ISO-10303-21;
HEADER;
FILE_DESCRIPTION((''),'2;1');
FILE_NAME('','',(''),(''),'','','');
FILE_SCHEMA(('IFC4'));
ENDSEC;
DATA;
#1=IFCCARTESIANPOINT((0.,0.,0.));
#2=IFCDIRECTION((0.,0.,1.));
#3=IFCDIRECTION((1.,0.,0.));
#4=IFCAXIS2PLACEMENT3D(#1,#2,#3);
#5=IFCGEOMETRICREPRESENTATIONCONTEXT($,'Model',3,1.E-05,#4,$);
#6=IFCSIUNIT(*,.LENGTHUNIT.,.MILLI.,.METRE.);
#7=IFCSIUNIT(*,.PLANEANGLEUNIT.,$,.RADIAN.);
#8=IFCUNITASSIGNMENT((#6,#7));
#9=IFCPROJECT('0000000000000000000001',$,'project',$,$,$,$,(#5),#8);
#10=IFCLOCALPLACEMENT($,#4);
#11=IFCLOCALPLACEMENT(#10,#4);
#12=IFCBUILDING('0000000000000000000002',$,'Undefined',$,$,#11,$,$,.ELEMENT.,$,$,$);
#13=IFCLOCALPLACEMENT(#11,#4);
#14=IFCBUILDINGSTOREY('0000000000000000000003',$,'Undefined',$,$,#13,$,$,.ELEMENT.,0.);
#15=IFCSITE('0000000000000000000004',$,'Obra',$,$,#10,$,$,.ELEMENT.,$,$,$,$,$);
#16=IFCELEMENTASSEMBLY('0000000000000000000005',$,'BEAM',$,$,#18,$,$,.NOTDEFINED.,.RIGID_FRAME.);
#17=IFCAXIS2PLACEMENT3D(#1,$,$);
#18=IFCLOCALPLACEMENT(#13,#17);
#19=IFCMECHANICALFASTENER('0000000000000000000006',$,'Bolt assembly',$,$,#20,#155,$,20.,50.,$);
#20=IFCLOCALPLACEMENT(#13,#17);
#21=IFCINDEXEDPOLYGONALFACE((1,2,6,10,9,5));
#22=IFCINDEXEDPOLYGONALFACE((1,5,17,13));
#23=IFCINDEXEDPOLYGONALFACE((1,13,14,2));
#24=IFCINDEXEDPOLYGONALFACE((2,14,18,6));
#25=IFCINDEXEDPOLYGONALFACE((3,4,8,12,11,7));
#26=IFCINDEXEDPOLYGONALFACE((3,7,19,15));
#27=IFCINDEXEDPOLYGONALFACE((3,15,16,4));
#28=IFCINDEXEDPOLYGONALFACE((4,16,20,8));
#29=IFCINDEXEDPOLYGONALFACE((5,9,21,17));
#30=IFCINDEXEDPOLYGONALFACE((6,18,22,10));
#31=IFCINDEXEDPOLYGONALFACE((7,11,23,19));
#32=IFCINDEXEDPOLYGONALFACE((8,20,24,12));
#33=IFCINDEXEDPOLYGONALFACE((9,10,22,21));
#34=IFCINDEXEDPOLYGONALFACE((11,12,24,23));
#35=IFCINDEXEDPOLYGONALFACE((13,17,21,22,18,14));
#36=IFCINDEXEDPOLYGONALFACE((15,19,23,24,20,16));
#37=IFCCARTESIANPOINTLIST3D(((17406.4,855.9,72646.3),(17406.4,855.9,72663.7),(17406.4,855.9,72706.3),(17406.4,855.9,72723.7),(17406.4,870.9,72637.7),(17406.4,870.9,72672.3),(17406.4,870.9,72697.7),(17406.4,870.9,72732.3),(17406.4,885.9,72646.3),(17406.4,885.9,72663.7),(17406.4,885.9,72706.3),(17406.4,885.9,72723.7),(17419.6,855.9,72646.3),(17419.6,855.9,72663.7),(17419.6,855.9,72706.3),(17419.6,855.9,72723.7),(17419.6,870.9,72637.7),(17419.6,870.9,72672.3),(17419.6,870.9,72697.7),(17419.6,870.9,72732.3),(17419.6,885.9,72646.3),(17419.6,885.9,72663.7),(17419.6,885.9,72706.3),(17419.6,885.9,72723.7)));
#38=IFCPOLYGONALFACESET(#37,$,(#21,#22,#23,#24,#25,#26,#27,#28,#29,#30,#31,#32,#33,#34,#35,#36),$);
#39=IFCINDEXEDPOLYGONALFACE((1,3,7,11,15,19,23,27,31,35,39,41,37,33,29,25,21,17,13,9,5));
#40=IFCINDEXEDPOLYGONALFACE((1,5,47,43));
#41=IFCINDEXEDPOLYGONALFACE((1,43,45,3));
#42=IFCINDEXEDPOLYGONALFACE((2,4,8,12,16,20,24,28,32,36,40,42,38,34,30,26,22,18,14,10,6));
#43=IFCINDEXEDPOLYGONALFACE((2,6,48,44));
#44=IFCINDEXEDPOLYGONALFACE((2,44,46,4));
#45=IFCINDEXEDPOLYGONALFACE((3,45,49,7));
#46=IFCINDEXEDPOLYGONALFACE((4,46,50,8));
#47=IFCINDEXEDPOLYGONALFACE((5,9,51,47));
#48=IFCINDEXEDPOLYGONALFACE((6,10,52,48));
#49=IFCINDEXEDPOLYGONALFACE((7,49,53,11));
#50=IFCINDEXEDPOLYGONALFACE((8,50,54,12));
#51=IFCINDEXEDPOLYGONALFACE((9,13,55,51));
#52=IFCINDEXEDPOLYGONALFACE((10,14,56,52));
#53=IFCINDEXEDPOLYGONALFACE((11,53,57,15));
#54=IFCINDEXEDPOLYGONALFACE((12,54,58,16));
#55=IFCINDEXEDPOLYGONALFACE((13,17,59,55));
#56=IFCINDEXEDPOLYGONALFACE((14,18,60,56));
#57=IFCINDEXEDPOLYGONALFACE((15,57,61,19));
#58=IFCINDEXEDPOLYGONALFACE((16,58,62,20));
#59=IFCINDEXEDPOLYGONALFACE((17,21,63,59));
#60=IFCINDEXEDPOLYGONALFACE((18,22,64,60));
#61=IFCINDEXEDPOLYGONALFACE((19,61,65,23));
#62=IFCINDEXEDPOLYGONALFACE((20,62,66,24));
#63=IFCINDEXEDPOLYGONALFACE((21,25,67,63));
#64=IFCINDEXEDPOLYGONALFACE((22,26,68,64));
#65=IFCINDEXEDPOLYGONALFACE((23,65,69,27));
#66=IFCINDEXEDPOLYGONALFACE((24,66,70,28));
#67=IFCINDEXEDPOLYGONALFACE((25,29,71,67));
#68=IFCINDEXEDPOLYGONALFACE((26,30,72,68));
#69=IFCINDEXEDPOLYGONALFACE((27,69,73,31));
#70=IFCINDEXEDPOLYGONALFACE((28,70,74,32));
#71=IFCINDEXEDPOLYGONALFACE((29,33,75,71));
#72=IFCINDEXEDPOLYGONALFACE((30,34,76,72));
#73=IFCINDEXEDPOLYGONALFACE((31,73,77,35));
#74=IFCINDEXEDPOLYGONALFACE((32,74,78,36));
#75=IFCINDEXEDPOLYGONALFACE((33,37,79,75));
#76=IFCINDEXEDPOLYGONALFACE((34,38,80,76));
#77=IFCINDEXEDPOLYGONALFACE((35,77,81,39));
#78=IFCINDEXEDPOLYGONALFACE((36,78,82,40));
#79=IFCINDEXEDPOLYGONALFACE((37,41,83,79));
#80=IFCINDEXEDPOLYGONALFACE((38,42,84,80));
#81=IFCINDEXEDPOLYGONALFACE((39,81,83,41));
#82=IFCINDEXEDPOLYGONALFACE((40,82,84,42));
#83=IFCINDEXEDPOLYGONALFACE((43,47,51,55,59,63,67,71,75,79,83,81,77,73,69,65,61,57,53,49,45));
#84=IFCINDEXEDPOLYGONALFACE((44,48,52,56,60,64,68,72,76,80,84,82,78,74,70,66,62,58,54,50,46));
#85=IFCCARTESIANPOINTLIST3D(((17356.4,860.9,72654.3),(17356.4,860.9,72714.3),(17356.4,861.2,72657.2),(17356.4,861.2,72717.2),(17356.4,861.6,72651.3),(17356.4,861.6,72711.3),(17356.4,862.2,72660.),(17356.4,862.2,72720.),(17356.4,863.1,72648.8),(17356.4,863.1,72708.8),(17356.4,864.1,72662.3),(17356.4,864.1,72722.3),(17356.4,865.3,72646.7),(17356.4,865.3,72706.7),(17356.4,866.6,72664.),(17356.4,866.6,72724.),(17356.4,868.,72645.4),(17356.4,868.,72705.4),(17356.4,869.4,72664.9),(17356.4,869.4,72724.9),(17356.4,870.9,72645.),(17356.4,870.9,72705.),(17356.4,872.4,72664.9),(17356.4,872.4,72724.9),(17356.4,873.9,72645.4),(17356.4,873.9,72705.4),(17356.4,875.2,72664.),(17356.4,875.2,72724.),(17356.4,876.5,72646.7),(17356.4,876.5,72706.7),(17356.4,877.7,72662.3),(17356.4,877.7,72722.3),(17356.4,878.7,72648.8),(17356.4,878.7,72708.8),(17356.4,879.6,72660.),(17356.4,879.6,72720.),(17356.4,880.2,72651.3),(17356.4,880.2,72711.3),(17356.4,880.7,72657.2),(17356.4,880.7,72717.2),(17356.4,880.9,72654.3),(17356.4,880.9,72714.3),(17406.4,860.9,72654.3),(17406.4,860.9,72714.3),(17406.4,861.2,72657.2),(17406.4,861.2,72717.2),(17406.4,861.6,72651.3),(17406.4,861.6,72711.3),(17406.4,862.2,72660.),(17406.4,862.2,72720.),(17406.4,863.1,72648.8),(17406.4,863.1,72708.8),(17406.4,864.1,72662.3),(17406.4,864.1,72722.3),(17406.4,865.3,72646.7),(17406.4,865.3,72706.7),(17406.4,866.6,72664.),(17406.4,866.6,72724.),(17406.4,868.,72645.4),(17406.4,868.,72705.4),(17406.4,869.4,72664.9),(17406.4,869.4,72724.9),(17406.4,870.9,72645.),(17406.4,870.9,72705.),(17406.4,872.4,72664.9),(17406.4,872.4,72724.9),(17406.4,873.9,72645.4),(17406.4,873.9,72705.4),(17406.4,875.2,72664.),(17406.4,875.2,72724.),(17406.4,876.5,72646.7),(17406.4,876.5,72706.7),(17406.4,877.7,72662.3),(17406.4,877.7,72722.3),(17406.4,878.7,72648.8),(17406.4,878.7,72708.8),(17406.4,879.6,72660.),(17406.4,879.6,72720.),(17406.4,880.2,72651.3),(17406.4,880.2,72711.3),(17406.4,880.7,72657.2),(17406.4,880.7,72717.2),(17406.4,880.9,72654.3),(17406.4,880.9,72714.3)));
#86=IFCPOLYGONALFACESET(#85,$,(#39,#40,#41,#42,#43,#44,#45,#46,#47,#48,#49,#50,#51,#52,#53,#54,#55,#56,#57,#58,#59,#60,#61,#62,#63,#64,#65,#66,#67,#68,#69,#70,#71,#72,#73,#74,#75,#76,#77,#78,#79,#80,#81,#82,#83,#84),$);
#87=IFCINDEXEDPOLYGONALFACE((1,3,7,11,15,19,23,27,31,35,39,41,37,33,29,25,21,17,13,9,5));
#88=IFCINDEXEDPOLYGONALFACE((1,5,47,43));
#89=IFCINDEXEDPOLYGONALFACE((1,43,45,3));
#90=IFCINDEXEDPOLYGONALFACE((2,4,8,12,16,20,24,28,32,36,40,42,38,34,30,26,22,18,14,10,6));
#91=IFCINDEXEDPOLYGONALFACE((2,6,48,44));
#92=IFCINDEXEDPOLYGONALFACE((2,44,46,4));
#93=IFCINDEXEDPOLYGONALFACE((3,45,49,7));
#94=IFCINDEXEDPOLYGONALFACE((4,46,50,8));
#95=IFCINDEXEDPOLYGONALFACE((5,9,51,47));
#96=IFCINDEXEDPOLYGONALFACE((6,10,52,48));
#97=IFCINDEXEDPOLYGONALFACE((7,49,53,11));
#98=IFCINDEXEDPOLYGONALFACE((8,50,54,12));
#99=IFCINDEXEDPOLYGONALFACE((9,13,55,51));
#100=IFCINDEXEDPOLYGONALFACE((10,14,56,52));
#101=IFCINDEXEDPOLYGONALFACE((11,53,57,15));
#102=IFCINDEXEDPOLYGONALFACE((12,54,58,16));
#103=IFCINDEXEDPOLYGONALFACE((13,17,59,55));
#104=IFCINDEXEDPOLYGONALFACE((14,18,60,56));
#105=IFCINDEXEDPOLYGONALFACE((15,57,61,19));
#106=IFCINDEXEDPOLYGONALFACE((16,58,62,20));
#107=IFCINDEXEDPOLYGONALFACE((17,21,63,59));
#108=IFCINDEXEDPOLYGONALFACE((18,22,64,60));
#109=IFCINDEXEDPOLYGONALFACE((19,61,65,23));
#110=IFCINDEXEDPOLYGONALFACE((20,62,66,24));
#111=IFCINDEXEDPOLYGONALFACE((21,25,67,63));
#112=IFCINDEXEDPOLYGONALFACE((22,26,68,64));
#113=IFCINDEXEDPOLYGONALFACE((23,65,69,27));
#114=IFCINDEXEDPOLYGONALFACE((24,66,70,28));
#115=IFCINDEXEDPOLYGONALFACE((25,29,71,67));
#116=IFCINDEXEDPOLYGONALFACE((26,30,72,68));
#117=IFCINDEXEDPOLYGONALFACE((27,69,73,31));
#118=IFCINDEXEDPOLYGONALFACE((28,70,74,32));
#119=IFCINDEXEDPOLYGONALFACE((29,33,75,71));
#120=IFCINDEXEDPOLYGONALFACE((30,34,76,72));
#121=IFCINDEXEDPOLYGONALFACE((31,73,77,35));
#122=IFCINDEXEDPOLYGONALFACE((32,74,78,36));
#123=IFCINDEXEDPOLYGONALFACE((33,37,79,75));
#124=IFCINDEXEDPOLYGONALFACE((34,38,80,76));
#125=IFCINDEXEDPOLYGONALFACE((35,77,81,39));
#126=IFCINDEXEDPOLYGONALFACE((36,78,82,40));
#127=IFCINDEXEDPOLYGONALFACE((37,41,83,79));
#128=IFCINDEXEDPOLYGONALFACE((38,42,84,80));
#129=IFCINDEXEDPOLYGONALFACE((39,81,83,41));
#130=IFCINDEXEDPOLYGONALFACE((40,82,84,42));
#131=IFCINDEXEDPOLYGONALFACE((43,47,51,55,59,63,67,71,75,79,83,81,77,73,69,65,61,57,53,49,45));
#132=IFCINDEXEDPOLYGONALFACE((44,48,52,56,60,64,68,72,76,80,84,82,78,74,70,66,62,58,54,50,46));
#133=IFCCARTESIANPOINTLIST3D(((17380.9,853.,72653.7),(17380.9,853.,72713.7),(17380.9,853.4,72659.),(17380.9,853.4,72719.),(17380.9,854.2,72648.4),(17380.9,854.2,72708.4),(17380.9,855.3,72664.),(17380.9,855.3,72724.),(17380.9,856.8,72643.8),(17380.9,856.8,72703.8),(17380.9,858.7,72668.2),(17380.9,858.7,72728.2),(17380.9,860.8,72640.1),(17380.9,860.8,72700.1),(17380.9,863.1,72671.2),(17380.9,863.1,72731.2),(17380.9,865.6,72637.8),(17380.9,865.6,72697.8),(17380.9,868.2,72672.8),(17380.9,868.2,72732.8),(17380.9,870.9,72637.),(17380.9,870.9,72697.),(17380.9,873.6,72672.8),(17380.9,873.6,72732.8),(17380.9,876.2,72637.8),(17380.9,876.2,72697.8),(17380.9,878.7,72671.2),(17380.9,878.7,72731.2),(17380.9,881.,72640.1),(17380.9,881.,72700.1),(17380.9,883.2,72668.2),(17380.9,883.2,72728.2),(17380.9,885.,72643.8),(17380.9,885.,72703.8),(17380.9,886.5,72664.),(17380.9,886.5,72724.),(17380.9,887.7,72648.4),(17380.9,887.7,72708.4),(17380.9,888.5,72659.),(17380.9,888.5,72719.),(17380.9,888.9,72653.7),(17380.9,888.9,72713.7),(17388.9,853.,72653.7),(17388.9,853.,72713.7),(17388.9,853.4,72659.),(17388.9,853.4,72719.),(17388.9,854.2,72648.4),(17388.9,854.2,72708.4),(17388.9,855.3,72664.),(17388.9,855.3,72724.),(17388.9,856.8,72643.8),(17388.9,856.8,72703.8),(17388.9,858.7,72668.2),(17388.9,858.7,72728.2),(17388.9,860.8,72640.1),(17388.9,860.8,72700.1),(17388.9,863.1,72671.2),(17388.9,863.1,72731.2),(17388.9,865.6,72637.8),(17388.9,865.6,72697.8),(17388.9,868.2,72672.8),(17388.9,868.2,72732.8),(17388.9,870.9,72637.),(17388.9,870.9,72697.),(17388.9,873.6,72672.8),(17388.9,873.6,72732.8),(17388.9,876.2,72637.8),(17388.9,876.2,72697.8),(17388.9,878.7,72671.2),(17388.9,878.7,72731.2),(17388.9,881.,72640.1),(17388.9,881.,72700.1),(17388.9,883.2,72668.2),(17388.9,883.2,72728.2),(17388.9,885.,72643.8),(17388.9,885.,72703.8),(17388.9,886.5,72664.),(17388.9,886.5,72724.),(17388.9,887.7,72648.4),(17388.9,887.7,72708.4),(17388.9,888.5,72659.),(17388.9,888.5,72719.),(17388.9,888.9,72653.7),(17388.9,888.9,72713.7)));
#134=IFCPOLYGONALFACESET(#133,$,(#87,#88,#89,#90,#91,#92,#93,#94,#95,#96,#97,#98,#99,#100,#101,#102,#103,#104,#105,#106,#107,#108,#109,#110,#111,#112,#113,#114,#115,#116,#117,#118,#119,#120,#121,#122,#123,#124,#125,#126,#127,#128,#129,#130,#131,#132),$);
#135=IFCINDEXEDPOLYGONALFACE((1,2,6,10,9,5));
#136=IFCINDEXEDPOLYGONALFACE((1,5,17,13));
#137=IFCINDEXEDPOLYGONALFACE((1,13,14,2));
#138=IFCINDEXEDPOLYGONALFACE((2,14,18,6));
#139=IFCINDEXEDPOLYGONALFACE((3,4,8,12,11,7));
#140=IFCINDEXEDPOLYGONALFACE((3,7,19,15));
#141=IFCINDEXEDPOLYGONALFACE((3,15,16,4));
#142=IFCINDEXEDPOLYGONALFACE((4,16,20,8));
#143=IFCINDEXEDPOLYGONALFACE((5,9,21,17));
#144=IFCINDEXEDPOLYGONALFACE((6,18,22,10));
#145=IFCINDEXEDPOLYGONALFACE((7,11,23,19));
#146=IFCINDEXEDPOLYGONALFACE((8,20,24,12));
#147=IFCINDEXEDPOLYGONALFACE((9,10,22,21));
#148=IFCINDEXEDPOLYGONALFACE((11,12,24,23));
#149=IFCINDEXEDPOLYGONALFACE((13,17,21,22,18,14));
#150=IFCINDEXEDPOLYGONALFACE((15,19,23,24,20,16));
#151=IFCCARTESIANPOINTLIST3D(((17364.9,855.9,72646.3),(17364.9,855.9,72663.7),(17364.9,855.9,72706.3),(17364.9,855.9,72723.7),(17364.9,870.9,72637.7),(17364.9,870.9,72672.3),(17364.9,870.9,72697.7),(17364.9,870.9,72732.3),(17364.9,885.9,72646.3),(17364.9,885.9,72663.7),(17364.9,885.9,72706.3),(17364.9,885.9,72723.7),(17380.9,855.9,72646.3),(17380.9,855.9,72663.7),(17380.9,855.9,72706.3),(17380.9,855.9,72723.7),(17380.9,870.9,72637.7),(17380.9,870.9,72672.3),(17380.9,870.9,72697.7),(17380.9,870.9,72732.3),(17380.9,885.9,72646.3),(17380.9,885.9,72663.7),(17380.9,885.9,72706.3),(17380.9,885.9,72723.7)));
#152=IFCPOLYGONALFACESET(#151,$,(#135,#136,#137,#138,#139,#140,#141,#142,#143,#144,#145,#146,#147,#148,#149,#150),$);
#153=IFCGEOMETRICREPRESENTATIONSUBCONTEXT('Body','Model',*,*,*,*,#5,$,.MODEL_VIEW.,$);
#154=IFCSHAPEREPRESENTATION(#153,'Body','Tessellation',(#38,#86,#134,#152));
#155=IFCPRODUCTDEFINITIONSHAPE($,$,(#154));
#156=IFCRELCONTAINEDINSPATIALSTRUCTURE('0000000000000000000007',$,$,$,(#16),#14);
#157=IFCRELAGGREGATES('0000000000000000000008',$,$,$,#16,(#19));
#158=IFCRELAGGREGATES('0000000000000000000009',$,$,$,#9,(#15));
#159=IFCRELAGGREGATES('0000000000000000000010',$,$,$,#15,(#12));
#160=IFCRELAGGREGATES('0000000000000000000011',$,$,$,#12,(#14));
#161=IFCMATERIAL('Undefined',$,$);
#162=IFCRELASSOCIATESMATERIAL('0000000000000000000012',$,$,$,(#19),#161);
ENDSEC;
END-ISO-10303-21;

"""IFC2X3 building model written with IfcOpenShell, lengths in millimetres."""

from ifc_helpers import new_model, si_unit, frame, origin_with_axes, origin_2d_with_axis, place, context, subcontext, project, spatial, polyline, circle, outline, extrude, source, transform, mapped, material, element, aggregate, save


model = new_model("IFC2X3")

# Units and contexts
model_context = context("Model", 3, precision=1e-05, world=origin_with_axes())
body_context = subcontext(model_context, "Body", "Model", "MODEL_VIEW")
ifc_project = project(units=[si_unit("LENGTHUNIT", "METRE", prefix="MILLI"), si_unit("PLANEANGLEUNIT", "RADIAN")], contexts=[model_context])

# Site, building, storey
site_placement = place(None, origin_with_axes())
site = spatial("IfcSite", under=ifc_project, at=site_placement, Name="Obra", CompositionType="ELEMENT")
building_placement = place(site_placement, origin_with_axes())
building = spatial("IfcBuilding", under=site, at=building_placement, Name="Undefined", CompositionType="ELEMENT")
storey_placement = place(building_placement, origin_with_axes())
storey = spatial("IfcBuildingStorey", under=building, at=storey_placement, Name="Undefined", CompositionType="ELEMENT", Elevation=0.0)

# Shared definitions
ifc_material = material(Name="Undefined")

# Shared definitions
shared_shape_1 = source(origin_with_axes(), body_context, "Body", "SweptSolid", [
    extrude(outline(polyline([(17.3, 0.0), (8.7, 15.0), (-8.7, 15.0), (-17.3, 0.0), (-8.7, -15.0), (8.7, -15.0), (17.3, 0.0)])), frame((0.0, -27.0, 0.0), z_axis=(0.0, 1.0, 0.0), x_axis=(1.0, 0.0, 0.0)), (0.0, 0.0, 1.0), 13.2),
    extrude(circle(Radius=10.0, at=origin_2d_with_axis()), frame((0.0, -13.8, 0.0), z_axis=(0.0, 1.0, 0.0), x_axis=(1.0, 0.0, 0.0)), (0.0, 0.0, 1.0), 50.0),
    extrude(circle(Radius=18.0, at=origin_2d_with_axis()), frame((0.0, 3.7, 0.0), z_axis=(0.0, 1.0, 0.0), x_axis=(1.0, 0.0, 0.0)), (0.0, 0.0, 1.0), 8.0),
    extrude(outline(polyline([(17.3, 0.0), (8.7, 15.0), (-8.7, 15.0), (-17.3, 0.0), (-8.7, -15.0), (8.7, -15.0), (17.3, 0.0)])), frame((0.0, 11.7, 0.0), z_axis=(0.0, 1.0, 0.0), x_axis=(1.0, 0.0, 0.0)), (0.0, 0.0, 1.0), 16.0),
])

# Element assembly
assembly_1_placement = place(storey_placement, origin_with_axes())
assembly_1 = element("IfcElementAssembly", 1, at=assembly_1_placement, inside=storey, Name="BEAM", AssemblyPlace="NOTDEFINED", PredefinedType="RIGID_FRAME")

# Mechanical fastener
mechanical_fastener_1_placement = place(assembly_1_placement, frame((17392.7, 830.9, 72850.0), z_axis=(0.0, 1.0, 0.0), x_axis=(0.0, 0.0, -1.0)))
mechanical_fastener_1 = element("IfcMechanicalFastener", 2, at=mechanical_fastener_1_placement, material=ifc_material, Name="Bolt assembly", NominalDiameter=20.0, NominalLength=50.0, context=body_context, shape_type="MappedRepresentation", body=[
    mapped(shared_shape_1, transform((135.0, 0.0, 40.0))),
    mapped(shared_shape_1, transform((195.0, 0.0, 40.0))),
])
aggregate(assembly_1, [mechanical_fastener_1])

save(model, "model.ifc")
